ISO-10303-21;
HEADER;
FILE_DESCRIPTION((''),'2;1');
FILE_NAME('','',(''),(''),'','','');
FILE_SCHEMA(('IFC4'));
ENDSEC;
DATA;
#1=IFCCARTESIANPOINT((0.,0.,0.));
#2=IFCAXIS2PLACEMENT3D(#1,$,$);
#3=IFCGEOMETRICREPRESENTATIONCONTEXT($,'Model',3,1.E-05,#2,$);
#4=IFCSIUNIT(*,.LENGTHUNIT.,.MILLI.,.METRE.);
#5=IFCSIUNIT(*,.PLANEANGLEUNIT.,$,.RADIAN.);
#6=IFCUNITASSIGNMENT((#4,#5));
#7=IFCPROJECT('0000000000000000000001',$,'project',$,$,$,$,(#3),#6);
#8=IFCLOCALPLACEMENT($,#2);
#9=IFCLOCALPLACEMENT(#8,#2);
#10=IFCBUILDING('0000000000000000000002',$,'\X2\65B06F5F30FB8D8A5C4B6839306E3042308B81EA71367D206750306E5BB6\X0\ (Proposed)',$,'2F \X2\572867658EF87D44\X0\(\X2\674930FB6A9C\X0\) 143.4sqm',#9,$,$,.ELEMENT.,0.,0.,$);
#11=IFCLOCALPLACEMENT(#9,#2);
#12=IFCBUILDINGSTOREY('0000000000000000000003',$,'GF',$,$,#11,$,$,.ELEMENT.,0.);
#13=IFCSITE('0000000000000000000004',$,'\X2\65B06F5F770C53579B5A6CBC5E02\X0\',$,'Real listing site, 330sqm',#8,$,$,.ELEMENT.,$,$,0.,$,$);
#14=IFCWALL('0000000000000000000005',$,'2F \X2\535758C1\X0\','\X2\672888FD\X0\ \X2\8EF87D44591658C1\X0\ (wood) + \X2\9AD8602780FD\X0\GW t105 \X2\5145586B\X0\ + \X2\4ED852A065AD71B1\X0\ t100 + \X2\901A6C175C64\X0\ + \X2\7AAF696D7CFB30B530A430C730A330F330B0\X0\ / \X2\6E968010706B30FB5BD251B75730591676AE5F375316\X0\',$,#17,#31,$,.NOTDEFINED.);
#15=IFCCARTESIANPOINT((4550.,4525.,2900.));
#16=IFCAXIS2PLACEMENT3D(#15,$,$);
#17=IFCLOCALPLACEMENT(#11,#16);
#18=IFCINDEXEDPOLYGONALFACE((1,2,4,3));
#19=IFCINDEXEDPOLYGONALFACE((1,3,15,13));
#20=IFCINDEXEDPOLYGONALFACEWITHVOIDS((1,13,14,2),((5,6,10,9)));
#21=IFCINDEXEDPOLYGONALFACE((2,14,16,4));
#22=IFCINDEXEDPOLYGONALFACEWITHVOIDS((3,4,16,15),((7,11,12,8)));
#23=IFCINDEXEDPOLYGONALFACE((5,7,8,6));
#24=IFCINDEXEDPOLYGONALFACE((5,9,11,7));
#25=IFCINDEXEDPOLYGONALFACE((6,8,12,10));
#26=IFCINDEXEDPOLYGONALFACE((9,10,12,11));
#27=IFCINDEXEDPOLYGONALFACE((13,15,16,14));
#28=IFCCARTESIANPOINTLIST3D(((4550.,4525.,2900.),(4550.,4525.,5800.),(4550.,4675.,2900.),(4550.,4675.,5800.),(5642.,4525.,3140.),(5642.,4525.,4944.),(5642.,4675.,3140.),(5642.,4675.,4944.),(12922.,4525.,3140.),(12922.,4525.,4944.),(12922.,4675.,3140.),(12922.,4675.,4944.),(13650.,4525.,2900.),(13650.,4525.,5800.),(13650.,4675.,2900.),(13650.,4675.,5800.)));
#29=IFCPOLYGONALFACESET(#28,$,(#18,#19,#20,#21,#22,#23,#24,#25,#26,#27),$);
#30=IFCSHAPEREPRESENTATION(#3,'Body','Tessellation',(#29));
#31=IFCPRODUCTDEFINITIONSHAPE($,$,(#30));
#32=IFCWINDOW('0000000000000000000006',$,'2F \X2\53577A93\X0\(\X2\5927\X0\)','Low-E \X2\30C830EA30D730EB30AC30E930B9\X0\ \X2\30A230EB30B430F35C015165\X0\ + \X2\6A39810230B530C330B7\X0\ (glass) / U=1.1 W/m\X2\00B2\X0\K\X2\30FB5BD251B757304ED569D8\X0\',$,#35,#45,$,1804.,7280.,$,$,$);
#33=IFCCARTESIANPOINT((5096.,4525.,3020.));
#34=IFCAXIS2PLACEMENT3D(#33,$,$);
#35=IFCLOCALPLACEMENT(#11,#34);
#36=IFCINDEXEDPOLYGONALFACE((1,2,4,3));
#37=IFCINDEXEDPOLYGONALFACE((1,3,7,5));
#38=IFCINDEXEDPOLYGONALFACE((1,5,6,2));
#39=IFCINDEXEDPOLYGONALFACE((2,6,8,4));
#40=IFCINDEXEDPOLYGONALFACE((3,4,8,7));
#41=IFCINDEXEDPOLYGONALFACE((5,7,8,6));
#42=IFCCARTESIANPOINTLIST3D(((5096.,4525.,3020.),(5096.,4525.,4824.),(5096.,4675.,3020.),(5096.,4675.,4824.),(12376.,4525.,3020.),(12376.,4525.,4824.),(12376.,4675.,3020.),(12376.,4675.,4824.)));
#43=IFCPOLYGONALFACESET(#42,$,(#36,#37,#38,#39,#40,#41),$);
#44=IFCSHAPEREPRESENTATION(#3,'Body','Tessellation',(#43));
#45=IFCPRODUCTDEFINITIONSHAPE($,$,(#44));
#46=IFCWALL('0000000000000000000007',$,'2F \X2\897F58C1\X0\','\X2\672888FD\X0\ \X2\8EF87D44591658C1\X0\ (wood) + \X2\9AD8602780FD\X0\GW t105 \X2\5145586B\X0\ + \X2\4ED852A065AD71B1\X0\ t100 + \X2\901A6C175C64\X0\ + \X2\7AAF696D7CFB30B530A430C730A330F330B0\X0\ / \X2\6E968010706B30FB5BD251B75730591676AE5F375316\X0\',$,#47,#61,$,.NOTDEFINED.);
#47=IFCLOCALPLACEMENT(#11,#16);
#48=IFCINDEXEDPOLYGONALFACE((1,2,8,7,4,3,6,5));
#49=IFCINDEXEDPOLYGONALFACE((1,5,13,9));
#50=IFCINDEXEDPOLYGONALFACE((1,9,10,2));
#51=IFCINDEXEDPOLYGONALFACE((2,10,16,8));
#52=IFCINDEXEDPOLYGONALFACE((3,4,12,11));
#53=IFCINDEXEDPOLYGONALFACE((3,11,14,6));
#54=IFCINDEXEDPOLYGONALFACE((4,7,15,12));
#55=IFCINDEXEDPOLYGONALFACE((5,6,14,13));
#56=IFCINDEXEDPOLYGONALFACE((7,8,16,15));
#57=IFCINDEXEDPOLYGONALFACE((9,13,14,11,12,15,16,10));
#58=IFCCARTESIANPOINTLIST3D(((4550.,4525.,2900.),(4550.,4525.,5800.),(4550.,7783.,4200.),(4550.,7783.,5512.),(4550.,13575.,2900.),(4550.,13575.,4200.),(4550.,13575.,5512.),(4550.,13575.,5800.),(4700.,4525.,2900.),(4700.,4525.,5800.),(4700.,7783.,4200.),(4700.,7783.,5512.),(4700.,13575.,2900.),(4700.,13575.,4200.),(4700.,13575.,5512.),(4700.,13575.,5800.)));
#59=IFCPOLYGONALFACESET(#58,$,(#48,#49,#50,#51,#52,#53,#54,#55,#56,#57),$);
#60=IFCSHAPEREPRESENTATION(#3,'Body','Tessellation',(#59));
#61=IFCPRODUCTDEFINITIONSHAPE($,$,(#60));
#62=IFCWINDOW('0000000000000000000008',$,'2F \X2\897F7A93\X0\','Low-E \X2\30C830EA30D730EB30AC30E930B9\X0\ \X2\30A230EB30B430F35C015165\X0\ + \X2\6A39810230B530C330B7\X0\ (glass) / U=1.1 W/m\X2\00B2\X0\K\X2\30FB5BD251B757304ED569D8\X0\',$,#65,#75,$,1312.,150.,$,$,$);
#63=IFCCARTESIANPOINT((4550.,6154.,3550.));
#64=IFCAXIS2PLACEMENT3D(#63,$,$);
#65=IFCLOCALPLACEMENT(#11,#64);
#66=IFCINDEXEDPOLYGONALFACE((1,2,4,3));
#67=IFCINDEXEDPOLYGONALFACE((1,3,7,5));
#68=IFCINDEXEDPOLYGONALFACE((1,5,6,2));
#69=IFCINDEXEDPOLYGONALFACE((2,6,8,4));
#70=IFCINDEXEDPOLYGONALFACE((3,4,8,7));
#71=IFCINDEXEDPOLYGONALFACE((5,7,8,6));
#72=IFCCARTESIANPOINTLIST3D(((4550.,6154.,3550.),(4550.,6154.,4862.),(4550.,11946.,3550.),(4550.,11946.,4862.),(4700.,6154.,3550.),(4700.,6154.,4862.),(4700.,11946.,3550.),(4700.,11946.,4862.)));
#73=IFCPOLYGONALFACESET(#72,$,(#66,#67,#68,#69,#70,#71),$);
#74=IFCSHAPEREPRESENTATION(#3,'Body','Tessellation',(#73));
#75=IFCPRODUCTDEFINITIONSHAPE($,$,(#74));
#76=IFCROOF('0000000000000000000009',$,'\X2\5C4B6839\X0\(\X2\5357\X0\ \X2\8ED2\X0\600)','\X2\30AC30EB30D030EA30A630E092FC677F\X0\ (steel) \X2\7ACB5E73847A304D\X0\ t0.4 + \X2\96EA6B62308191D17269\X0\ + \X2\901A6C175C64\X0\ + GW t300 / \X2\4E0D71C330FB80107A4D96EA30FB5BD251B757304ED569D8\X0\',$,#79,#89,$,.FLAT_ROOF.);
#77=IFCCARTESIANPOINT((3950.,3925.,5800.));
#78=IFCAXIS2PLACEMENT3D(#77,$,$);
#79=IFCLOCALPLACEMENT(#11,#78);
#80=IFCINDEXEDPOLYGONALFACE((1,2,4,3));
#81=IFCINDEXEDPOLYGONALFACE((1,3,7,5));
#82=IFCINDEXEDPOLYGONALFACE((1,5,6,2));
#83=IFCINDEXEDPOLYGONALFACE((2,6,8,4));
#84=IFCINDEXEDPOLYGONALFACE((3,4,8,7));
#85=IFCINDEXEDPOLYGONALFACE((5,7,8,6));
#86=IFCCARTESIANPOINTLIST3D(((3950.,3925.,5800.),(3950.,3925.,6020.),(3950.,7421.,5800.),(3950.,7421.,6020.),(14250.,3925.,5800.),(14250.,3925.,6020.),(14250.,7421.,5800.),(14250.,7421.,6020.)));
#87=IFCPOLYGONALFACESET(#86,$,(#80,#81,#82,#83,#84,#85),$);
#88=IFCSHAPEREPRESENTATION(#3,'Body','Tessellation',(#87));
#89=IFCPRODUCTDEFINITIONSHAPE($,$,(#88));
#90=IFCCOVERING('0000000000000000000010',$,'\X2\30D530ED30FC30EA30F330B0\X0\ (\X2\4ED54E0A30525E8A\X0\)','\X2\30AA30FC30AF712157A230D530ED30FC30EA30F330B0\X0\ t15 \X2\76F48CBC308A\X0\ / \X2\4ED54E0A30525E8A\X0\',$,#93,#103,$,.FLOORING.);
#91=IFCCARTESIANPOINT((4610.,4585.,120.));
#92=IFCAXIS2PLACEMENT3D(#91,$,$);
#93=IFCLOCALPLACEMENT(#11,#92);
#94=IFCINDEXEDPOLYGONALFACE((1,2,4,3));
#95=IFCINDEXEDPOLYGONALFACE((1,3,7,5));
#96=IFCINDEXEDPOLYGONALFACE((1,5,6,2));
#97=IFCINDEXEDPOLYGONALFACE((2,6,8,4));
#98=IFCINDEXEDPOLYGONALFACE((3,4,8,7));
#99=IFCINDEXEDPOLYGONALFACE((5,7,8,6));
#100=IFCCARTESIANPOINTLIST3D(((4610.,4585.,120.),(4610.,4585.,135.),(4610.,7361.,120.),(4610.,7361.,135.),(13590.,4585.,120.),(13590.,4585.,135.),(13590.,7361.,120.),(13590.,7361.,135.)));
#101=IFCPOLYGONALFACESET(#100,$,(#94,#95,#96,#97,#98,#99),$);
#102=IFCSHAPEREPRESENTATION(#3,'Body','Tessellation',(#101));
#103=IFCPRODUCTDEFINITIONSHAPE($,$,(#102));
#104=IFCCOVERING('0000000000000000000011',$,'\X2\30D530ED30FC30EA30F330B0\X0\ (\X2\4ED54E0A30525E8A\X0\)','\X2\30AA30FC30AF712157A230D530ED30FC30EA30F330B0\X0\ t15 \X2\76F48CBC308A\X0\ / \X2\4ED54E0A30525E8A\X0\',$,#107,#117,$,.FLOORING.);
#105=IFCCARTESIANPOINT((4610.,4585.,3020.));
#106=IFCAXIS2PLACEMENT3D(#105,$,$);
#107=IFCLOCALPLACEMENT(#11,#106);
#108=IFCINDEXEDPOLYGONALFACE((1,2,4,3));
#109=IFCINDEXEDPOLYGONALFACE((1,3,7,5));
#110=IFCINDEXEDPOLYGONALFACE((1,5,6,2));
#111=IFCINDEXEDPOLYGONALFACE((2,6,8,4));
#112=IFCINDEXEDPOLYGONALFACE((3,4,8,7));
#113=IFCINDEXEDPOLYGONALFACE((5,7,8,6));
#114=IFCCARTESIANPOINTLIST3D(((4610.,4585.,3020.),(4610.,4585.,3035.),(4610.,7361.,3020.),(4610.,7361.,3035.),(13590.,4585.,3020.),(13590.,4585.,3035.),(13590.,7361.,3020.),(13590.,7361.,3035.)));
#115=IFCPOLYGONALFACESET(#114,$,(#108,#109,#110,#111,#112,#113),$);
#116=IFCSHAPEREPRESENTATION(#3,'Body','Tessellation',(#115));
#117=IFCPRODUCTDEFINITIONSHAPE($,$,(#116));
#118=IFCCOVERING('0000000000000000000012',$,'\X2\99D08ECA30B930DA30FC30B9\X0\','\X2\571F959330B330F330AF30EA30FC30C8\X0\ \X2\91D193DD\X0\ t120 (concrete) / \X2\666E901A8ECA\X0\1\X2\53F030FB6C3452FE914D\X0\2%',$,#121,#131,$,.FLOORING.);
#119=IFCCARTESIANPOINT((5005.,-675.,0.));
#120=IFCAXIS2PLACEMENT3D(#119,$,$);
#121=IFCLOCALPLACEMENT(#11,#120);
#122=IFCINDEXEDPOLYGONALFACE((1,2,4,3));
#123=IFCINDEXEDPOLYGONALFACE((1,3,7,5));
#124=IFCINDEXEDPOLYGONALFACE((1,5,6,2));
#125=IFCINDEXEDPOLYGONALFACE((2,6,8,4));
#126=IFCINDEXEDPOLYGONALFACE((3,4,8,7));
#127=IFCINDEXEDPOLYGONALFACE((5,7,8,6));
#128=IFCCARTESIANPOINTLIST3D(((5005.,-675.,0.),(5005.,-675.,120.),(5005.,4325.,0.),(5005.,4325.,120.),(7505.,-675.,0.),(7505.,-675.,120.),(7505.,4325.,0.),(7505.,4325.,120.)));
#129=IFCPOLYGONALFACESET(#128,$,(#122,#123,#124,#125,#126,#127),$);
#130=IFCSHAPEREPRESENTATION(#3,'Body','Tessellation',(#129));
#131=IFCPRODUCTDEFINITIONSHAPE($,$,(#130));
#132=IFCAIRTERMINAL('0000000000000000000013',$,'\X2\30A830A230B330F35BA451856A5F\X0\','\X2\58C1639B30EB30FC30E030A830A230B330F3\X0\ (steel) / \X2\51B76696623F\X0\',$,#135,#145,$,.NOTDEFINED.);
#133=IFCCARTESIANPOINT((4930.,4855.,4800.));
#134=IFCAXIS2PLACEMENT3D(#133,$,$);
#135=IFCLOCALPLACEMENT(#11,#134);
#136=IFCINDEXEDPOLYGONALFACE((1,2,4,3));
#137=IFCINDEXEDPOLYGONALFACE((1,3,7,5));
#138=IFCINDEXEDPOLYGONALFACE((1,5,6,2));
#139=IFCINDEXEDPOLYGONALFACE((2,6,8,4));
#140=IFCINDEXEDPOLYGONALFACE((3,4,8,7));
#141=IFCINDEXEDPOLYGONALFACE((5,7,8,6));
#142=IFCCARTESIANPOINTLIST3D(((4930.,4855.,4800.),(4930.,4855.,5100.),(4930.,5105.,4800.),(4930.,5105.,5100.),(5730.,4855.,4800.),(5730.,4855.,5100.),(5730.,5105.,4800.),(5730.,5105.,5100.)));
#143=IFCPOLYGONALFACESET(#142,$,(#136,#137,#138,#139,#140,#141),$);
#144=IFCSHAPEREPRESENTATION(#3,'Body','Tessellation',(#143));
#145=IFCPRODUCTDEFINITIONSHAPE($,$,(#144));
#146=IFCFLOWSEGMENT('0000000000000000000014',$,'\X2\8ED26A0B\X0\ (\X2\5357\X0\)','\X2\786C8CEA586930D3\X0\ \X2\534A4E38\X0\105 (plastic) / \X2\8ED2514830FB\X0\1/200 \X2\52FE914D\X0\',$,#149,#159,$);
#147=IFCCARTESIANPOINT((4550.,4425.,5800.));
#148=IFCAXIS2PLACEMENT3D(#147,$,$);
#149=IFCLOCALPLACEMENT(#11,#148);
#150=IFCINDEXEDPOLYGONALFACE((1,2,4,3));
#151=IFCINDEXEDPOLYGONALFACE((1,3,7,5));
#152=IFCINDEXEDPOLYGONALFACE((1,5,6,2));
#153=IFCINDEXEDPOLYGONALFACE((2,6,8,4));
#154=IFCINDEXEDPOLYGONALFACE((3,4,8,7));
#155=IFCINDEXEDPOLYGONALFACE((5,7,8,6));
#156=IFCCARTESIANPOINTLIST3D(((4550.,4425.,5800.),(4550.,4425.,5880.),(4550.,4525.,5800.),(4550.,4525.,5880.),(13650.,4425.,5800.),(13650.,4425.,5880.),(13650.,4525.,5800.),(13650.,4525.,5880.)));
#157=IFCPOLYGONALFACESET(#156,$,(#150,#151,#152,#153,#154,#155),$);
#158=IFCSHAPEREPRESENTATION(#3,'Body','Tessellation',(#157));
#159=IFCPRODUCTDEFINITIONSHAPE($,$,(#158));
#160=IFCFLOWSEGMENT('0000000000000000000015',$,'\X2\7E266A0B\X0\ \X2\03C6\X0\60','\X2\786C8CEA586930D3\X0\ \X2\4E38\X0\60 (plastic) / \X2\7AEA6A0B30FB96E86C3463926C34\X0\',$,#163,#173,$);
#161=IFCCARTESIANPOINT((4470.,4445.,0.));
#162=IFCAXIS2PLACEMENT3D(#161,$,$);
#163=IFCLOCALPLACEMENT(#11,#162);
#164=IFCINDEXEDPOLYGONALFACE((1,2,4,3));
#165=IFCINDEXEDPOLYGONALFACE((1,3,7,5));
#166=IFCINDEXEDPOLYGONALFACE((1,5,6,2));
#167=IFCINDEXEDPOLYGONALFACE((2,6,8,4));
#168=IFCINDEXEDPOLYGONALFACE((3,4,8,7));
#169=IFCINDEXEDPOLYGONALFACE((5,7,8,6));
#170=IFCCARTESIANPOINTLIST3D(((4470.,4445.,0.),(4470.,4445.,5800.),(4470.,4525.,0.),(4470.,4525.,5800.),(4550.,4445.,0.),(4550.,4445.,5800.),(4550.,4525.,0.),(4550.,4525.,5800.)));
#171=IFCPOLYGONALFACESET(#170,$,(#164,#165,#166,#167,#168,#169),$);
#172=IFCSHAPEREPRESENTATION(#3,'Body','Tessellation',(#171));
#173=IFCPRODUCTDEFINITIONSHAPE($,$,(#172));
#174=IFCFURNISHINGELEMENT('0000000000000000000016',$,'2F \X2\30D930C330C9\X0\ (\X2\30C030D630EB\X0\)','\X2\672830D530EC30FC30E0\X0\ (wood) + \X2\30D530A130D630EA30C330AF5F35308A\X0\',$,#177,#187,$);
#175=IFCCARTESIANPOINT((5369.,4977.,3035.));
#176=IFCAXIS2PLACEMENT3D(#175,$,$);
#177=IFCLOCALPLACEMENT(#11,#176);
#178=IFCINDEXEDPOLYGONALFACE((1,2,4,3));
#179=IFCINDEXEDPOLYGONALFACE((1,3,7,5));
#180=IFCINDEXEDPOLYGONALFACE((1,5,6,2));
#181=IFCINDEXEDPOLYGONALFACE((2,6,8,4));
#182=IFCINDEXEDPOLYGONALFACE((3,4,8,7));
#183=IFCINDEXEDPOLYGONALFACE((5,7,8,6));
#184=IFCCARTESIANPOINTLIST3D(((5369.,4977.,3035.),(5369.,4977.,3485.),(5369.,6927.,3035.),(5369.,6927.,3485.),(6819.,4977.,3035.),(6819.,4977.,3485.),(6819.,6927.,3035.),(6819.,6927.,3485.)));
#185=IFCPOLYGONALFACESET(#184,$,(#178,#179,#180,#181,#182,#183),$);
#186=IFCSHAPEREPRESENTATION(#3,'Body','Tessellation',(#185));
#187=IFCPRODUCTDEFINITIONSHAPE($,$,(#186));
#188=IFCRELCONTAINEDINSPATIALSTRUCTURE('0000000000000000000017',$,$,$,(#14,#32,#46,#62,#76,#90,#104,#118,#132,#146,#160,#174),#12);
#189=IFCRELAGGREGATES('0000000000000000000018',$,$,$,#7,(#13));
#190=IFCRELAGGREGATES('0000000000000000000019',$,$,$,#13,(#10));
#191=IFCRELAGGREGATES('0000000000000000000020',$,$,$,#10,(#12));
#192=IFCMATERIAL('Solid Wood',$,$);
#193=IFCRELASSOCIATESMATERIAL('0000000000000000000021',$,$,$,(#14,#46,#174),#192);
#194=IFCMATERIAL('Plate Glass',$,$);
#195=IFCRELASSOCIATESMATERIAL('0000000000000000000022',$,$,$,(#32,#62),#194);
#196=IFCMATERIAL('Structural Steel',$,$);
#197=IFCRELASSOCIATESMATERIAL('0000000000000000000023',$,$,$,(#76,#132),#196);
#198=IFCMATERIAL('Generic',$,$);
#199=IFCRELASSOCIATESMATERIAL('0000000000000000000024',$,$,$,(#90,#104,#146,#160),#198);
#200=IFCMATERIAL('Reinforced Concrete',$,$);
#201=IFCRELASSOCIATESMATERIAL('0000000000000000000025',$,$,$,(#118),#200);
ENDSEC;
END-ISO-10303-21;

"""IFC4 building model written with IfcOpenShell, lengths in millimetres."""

from ifc_helpers import new_model, si_unit, frame, frame_2d, origin, place, context, project, spatial, rectangle, extrude, material, element, fill, save


model = new_model("IFC4")

# Units and contexts
model_context = context("Model", 3, precision=1e-05, world=origin())
ifc_project = project(units=[si_unit("LENGTHUNIT", "METRE", prefix="MILLI"), si_unit("PLANEANGLEUNIT", "RADIAN")], contexts=[model_context])

# Site, building, storey
site_placement = place(None, origin())
site = spatial("IfcSite", under=ifc_project, at=site_placement, Name="新潟県南魚沼市", ObjectType="Real listing site, 330sqm", CompositionType="ELEMENT", RefElevation=0.0)
building_placement = place(site_placement, origin())
building = spatial("IfcBuilding", under=site, at=building_placement, Name="新潟・越屋根のある自然素材の家 (Proposed)", ObjectType="2F 在来軸組(杉・檜) 143.4sqm", CompositionType="ELEMENT", ElevationOfRefHeight=0.0, ElevationOfTerrain=0.0)
storey_placement = place(building_placement, origin())
storey = spatial("IfcBuildingStorey", under=building, at=storey_placement, Name="GF", CompositionType="ELEMENT", Elevation=0.0)

# Shared definitions
ifc_material_1 = material(Name="Solid Wood")

# Shared definitions
ifc_material_2 = material(Name="Reinforced Concrete")

# Shared definitions
ifc_material_3 = material(Name="Plate Glass")

# Walls, openings, windows
wall_1_placement = place(storey_placement, frame((4550.0, 4525.0, 2900.0)))
wall_1 = element("IfcWall", 1, at=wall_1_placement, inside=storey, material=ifc_material_1, Name="2F 南壁", Description="木製 軸組外壁 (wood) + 高性能GW t105 充填 + 付加断熱 t100 + 通気層 + 窯業系サイディング / 準耐火・寒冷地外皮強化", PredefinedType="NOTDEFINED", context=model_context, shape_type="SweptSolid", body=[
    extrude(rectangle(XDim=9100.0, YDim=150.0, at=frame_2d((4550.0, 75.0))), frame((4550.0, 4525.0, 2900.0)), (0.0, 0.0, 1.0), 2900.0),
])
opening_1_placement = place(storey_placement, frame((5096.0, 4525.0, 3020.0)))
opening_1 = element("IfcOpeningElement", 2, at=opening_1_placement, cuts=wall_1, PredefinedType="NOTDEFINED", context=model_context, shape_type="SweptSolid", body=[
    extrude(rectangle(XDim=7280.0, YDim=150.0, at=frame_2d((3640.0, 75.0))), frame((5096.0, 4525.0, 3020.0)), (0.0, 0.0, 1.0), 1804.0),
])
window_1_placement = place(storey_placement, frame((5096.0, 4525.0, 3020.0)))
window_1 = element("IfcWindow", 3, at=window_1_placement, inside=storey, material=ifc_material_3, Name="2F 南窓(大)", Description="Low-E トリプルガラス アルゴン封入 + 樹脂サッシ (glass) / U=1.1 W/m²K・寒冷地仕様", OverallHeight=1804.0, OverallWidth=7280.0, context=model_context, shape_type="SweptSolid", body=[
    extrude(rectangle(XDim=7280.0, YDim=150.0, at=frame_2d((3640.0, 75.0))), frame((5096.0, 4525.0, 3020.0)), (0.0, 0.0, 1.0), 1804.0),
])
fill(opening_1, window_1)
wall_2_placement = place(storey_placement, frame((4550.0, 4525.0, 2900.0)))
wall_2 = element("IfcWall", 4, at=wall_2_placement, inside=storey, material=ifc_material_1, Name="2F 西壁", Description="木製 軸組外壁 (wood) + 高性能GW t105 充填 + 付加断熱 t100 + 通気層 + 窯業系サイディング / 準耐火・寒冷地外皮強化", PredefinedType="NOTDEFINED", context=model_context, shape_type="SweptSolid", body=[
    extrude(rectangle(XDim=150.0, YDim=9050.0, at=frame_2d((75.0, 4525.0))), frame((4550.0, 4525.0, 2900.0)), (0.0, 0.0, 1.0), 2900.0),
])
opening_2_placement = place(storey_placement, frame((4550.0, 6154.0, 3550.0)))
opening_2 = element("IfcOpeningElement", 5, at=opening_2_placement, cuts=wall_2, PredefinedType="NOTDEFINED", context=model_context, shape_type="SweptSolid", body=[
    extrude(rectangle(XDim=150.0, YDim=5792.0, at=frame_2d((75.0, 2896.0))), frame((4550.0, 6154.0, 3550.0)), (0.0, 0.0, 1.0), 1312.0),
])
window_2_placement = place(storey_placement, frame((4550.0, 6154.0, 3550.0)))
window_2 = element("IfcWindow", 6, at=window_2_placement, inside=storey, material=ifc_material_3, Name="2F 西窓", Description="Low-E トリプルガラス アルゴン封入 + 樹脂サッシ (glass) / U=1.1 W/m²K・寒冷地仕様", OverallHeight=1312.0, OverallWidth=150.0, context=model_context, shape_type="SweptSolid", body=[
    extrude(rectangle(XDim=150.0, YDim=5792.0, at=frame_2d((75.0, 2896.0))), frame((4550.0, 6154.0, 3550.0)), (0.0, 0.0, 1.0), 1312.0),
])
fill(opening_2, window_2)

# Roof
ifc_material_4 = material(Name="Structural Steel")
for number, where, name in (
    (7, (3950.0, 3925.0, 5800.0), "屋根(南 軒600)"),
):
    element("IfcRoof", number, at=place(storey_placement, frame(where)), inside=storey, material=ifc_material_4, Name=name, Description="ガルバリウム鋼板 (steel) 立平葺き t0.4 + 雪止め金物 + 通気層 + GW t300 / 不燃・耐積雪・寒冷地仕様", PredefinedType="FLAT_ROOF", context=model_context, shape_type="SweptSolid", body=[
        extrude(rectangle(XDim=10300.0, YDim=3496.0, at=frame_2d((5150.0, 1748.0))), frame((3950.0, 3925.0, 5800.0)), (0.0, 0.0, 1.0), 220.0),
    ])

# Coverings
ifc_material_5 = material(Name="Generic")
covering_1_placement = place(storey_placement, frame((4610.0, 4585.0, 120.0)))
element("IfcCovering", 8, at=covering_1_placement, inside=storey, material=ifc_material_5, Name="フローリング (仕上げ床)", Description="オーク無垢フローリング t15 直貼り / 仕上げ床", PredefinedType="FLOORING", context=model_context, shape_type="SweptSolid", body=[
    extrude(rectangle(XDim=8980.0, YDim=2776.0, at=frame_2d((4490.0, 1388.0))), frame((4610.0, 4585.0, 120.0)), (0.0, 0.0, 1.0), 15.0),
])
covering_2_placement = place(storey_placement, frame((4610.0, 4585.0, 3020.0)))
element("IfcCovering", 9, at=covering_2_placement, inside=storey, material=ifc_material_5, Name="フローリング (仕上げ床)", Description="オーク無垢フローリング t15 直貼り / 仕上げ床", PredefinedType="FLOORING", context=model_context, shape_type="SweptSolid", body=[
    extrude(rectangle(XDim=8980.0, YDim=2776.0, at=frame_2d((4490.0, 1388.0))), frame((4610.0, 4585.0, 3020.0)), (0.0, 0.0, 1.0), 15.0),
])
covering_3_placement = place(storey_placement, frame((5005.0, -675.0, 0.0)))
element("IfcCovering", 10, at=covering_3_placement, inside=storey, material=ifc_material_2, Name="駐車スペース", Description="土間コンクリート 金鏝 t120 (concrete) / 普通車1台・水勾配2%", PredefinedType="FLOORING", context=model_context, shape_type="SweptSolid", body=[
    extrude(rectangle(XDim=2500.0, YDim=5000.0, at=frame_2d((1250.0, 2500.0))), frame((5005.0, -675.0, 0.0)), (0.0, 0.0, 1.0), 120.0),
])

# Air terminal
air_terminal_placement = place(storey_placement, frame((4930.0, 4855.0, 4800.0)))
element("IfcAirTerminal", 11, at=air_terminal_placement, inside=storey, material=ifc_material_4, Name="エアコン室内機", Description="壁掛ルームエアコン (steel) / 冷暖房", PredefinedType="NOTDEFINED", context=model_context, shape_type="SweptSolid", body=[
    extrude(rectangle(XDim=800.0, YDim=250.0, at=frame_2d((400.0, 125.0))), frame((4930.0, 4855.0, 4800.0)), (0.0, 0.0, 1.0), 300.0),
])

# Flow segments
flow_segment_1_placement = place(storey_placement, frame((4550.0, 4425.0, 5800.0)))
element("IfcFlowSegment", 12, at=flow_segment_1_placement, inside=storey, material=ifc_material_5, Name="軒樋 (南)", Description="硬質塩ビ 半丸105 (plastic) / 軒先・1/200 勾配", context=model_context, shape_type="SweptSolid", body=[
    extrude(rectangle(XDim=9100.0, YDim=100.0, at=frame_2d((4550.0, 50.0))), frame((4550.0, 4425.0, 5800.0)), (0.0, 0.0, 1.0), 80.0),
])
flow_segment_2_placement = place(storey_placement, frame((4470.0, 4445.0, 0.0)))
element("IfcFlowSegment", 13, at=flow_segment_2_placement, inside=storey, material=ifc_material_5, Name="縦樋 φ60", Description="硬質塩ビ 丸60 (plastic) / 竪樋・雨水排水", context=model_context, shape_type="SweptSolid", body=[
    extrude(rectangle(XDim=80.0, YDim=80.0, at=frame_2d((40.0, 40.0))), frame((4470.0, 4445.0, 0.0)), (0.0, 0.0, 1.0), 5800.0),
])

# Furnishing element
furnishing_placement = place(storey_placement, frame((5369.0, 4977.0, 3035.0)))
element("IfcFurnishingElement", 14, at=furnishing_placement, inside=storey, material=ifc_material_1, Name="2F ベッド (ダブル)", Description="木フレーム (wood) + ファブリック張り", context=model_context, shape_type="SweptSolid", body=[
    extrude(rectangle(XDim=1450.0, YDim=1950.0, at=frame_2d((725.0, 975.0))), frame((5369.0, 4977.0, 3035.0)), (0.0, 0.0, 1.0), 450.0),
])

save(model, "model.ifc")
